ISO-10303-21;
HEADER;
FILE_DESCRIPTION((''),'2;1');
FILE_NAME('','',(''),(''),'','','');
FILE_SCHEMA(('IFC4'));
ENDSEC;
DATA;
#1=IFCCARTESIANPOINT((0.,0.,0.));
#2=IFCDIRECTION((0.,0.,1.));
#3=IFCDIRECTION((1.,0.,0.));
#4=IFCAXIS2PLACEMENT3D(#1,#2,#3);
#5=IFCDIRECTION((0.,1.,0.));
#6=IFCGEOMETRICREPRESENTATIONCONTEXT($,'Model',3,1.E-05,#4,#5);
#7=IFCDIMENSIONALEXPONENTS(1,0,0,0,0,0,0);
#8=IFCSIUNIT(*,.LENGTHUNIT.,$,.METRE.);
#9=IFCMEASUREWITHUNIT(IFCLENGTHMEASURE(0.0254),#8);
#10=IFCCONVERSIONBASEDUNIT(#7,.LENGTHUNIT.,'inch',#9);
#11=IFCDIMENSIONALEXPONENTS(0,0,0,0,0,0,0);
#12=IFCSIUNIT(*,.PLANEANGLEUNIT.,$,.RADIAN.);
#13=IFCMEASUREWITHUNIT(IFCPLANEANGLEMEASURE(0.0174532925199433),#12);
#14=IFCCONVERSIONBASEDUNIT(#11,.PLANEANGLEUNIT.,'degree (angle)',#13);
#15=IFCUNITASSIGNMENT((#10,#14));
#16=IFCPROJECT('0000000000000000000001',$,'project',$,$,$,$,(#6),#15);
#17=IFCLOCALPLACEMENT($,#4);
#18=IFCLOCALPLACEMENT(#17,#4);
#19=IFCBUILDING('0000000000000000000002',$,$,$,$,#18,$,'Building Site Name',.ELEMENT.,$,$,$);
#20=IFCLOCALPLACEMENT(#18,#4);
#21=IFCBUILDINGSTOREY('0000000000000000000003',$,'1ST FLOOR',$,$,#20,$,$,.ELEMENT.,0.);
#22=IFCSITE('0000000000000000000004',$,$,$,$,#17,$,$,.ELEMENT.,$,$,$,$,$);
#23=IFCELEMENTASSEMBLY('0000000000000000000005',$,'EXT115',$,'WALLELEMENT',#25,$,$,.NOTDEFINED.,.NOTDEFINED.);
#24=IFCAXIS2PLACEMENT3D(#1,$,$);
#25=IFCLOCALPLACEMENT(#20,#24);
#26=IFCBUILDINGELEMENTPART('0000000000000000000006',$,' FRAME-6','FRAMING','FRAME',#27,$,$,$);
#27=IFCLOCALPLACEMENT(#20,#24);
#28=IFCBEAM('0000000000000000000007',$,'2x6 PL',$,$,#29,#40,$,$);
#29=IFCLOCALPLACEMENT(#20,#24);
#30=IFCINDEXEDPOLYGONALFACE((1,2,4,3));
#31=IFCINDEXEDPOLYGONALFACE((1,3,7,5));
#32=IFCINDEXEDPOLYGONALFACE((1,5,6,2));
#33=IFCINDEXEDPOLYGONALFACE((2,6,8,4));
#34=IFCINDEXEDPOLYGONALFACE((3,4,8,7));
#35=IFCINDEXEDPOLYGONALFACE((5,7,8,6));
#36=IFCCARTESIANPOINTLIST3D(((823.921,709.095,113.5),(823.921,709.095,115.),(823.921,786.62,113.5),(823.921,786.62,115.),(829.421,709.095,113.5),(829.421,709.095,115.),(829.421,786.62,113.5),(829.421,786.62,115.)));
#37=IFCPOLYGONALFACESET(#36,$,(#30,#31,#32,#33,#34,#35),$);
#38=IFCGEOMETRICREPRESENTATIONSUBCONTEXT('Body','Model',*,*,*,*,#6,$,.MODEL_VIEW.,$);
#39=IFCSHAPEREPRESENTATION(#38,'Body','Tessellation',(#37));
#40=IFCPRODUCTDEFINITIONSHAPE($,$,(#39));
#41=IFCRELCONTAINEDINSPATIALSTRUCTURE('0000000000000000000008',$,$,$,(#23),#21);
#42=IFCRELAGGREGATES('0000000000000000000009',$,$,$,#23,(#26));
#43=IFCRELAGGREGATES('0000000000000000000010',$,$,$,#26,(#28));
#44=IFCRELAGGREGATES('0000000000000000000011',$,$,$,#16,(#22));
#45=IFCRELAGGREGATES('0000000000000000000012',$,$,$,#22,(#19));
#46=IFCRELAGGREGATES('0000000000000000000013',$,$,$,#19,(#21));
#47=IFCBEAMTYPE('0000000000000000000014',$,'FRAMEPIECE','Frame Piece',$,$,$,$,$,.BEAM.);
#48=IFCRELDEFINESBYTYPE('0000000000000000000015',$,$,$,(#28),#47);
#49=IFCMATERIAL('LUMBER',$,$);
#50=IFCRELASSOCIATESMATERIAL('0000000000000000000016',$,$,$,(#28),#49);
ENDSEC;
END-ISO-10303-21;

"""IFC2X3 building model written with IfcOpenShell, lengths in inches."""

from ifc_helpers import new_model, entity, si_unit, converted_unit, direction, frame, frame_2d, origin_with_axes, place, context, subcontext, project, spatial, rectangle, extrude, material, type_object, element, aggregate, save


model = new_model("IFC2X3")

# Units and contexts
model_context = context("Model", 3, precision=1e-05, world=origin_with_axes(), true_north=direction((0.0, 1.0, 0.0)))
body_context = subcontext(model_context, "Body", "Model", "MODEL_VIEW")
ifc_project = project(units=[converted_unit("LENGTHUNIT", "inch", entity("IfcLengthMeasure", 0.0254), si_unit("LENGTHUNIT", "METRE"), dimensions=[1, 0, 0, 0, 0, 0, 0]), converted_unit("PLANEANGLEUNIT", "degree (angle)", entity("IfcPlaneAngleMeasure", 0.0174532925199433), si_unit("PLANEANGLEUNIT", "RADIAN"), dimensions=[0, 0, 0, 0, 0, 0, 0])], contexts=[model_context])

# Site, building, storey
site_placement = place(None, origin_with_axes())
site = spatial("IfcSite", under=ifc_project, at=site_placement, CompositionType="ELEMENT")
building_placement = place(site_placement, origin_with_axes())
building = spatial("IfcBuilding", under=site, at=building_placement, LongName="Building Site Name", CompositionType="ELEMENT")
storey_placement = place(building_placement, origin_with_axes())
storey = spatial("IfcBuildingStorey", under=building, at=storey_placement, Name="1ST FLOOR", CompositionType="ELEMENT", Elevation=0.0)

# Shared definitions
ifc_material_1 = material(Name="LUMBER")
beam_type = type_object("IfcBeamType", Name="FRAMEPIECE", Description="Frame Piece", PredefinedType="BEAM")

# Element assembly, building element part, beam
assembly_1_placement = place(storey_placement, origin_with_axes())
assembly_1 = element("IfcElementAssembly", 1, at=assembly_1_placement, inside=storey, Name="EXT115", ObjectType="WALLELEMENT", AssemblyPlace="NOTDEFINED", PredefinedType="NOTDEFINED")
building_element_part_1 = element("IfcBuildingElementPart", 2, Name=" FRAME-6", Description="FRAMING", ObjectType="FRAME")
aggregate(assembly_1, [building_element_part_1])
beam_1_placement = place(assembly_1_placement, frame((826.671, 786.62, 114.25), z_axis=(0.0, -1.0, 0.0), x_axis=(0.0, 0.0, -1.0)))
beam_1 = element("IfcBeam", 3, at=beam_1_placement, type_object=beam_type, material=ifc_material_1, Name="2x6 PL", context=body_context, shape_type="SweptSolid", body=[
    extrude(rectangle(XDim=1.5, YDim=5.5, at=frame_2d((0.0, 0.0), x_axis=(-1.0, 0.0))), origin_with_axes(), (0.0, 0.0, 1.0), 77.525),
])
aggregate(building_element_part_1, [beam_1])

save(model, "model.ifc")
